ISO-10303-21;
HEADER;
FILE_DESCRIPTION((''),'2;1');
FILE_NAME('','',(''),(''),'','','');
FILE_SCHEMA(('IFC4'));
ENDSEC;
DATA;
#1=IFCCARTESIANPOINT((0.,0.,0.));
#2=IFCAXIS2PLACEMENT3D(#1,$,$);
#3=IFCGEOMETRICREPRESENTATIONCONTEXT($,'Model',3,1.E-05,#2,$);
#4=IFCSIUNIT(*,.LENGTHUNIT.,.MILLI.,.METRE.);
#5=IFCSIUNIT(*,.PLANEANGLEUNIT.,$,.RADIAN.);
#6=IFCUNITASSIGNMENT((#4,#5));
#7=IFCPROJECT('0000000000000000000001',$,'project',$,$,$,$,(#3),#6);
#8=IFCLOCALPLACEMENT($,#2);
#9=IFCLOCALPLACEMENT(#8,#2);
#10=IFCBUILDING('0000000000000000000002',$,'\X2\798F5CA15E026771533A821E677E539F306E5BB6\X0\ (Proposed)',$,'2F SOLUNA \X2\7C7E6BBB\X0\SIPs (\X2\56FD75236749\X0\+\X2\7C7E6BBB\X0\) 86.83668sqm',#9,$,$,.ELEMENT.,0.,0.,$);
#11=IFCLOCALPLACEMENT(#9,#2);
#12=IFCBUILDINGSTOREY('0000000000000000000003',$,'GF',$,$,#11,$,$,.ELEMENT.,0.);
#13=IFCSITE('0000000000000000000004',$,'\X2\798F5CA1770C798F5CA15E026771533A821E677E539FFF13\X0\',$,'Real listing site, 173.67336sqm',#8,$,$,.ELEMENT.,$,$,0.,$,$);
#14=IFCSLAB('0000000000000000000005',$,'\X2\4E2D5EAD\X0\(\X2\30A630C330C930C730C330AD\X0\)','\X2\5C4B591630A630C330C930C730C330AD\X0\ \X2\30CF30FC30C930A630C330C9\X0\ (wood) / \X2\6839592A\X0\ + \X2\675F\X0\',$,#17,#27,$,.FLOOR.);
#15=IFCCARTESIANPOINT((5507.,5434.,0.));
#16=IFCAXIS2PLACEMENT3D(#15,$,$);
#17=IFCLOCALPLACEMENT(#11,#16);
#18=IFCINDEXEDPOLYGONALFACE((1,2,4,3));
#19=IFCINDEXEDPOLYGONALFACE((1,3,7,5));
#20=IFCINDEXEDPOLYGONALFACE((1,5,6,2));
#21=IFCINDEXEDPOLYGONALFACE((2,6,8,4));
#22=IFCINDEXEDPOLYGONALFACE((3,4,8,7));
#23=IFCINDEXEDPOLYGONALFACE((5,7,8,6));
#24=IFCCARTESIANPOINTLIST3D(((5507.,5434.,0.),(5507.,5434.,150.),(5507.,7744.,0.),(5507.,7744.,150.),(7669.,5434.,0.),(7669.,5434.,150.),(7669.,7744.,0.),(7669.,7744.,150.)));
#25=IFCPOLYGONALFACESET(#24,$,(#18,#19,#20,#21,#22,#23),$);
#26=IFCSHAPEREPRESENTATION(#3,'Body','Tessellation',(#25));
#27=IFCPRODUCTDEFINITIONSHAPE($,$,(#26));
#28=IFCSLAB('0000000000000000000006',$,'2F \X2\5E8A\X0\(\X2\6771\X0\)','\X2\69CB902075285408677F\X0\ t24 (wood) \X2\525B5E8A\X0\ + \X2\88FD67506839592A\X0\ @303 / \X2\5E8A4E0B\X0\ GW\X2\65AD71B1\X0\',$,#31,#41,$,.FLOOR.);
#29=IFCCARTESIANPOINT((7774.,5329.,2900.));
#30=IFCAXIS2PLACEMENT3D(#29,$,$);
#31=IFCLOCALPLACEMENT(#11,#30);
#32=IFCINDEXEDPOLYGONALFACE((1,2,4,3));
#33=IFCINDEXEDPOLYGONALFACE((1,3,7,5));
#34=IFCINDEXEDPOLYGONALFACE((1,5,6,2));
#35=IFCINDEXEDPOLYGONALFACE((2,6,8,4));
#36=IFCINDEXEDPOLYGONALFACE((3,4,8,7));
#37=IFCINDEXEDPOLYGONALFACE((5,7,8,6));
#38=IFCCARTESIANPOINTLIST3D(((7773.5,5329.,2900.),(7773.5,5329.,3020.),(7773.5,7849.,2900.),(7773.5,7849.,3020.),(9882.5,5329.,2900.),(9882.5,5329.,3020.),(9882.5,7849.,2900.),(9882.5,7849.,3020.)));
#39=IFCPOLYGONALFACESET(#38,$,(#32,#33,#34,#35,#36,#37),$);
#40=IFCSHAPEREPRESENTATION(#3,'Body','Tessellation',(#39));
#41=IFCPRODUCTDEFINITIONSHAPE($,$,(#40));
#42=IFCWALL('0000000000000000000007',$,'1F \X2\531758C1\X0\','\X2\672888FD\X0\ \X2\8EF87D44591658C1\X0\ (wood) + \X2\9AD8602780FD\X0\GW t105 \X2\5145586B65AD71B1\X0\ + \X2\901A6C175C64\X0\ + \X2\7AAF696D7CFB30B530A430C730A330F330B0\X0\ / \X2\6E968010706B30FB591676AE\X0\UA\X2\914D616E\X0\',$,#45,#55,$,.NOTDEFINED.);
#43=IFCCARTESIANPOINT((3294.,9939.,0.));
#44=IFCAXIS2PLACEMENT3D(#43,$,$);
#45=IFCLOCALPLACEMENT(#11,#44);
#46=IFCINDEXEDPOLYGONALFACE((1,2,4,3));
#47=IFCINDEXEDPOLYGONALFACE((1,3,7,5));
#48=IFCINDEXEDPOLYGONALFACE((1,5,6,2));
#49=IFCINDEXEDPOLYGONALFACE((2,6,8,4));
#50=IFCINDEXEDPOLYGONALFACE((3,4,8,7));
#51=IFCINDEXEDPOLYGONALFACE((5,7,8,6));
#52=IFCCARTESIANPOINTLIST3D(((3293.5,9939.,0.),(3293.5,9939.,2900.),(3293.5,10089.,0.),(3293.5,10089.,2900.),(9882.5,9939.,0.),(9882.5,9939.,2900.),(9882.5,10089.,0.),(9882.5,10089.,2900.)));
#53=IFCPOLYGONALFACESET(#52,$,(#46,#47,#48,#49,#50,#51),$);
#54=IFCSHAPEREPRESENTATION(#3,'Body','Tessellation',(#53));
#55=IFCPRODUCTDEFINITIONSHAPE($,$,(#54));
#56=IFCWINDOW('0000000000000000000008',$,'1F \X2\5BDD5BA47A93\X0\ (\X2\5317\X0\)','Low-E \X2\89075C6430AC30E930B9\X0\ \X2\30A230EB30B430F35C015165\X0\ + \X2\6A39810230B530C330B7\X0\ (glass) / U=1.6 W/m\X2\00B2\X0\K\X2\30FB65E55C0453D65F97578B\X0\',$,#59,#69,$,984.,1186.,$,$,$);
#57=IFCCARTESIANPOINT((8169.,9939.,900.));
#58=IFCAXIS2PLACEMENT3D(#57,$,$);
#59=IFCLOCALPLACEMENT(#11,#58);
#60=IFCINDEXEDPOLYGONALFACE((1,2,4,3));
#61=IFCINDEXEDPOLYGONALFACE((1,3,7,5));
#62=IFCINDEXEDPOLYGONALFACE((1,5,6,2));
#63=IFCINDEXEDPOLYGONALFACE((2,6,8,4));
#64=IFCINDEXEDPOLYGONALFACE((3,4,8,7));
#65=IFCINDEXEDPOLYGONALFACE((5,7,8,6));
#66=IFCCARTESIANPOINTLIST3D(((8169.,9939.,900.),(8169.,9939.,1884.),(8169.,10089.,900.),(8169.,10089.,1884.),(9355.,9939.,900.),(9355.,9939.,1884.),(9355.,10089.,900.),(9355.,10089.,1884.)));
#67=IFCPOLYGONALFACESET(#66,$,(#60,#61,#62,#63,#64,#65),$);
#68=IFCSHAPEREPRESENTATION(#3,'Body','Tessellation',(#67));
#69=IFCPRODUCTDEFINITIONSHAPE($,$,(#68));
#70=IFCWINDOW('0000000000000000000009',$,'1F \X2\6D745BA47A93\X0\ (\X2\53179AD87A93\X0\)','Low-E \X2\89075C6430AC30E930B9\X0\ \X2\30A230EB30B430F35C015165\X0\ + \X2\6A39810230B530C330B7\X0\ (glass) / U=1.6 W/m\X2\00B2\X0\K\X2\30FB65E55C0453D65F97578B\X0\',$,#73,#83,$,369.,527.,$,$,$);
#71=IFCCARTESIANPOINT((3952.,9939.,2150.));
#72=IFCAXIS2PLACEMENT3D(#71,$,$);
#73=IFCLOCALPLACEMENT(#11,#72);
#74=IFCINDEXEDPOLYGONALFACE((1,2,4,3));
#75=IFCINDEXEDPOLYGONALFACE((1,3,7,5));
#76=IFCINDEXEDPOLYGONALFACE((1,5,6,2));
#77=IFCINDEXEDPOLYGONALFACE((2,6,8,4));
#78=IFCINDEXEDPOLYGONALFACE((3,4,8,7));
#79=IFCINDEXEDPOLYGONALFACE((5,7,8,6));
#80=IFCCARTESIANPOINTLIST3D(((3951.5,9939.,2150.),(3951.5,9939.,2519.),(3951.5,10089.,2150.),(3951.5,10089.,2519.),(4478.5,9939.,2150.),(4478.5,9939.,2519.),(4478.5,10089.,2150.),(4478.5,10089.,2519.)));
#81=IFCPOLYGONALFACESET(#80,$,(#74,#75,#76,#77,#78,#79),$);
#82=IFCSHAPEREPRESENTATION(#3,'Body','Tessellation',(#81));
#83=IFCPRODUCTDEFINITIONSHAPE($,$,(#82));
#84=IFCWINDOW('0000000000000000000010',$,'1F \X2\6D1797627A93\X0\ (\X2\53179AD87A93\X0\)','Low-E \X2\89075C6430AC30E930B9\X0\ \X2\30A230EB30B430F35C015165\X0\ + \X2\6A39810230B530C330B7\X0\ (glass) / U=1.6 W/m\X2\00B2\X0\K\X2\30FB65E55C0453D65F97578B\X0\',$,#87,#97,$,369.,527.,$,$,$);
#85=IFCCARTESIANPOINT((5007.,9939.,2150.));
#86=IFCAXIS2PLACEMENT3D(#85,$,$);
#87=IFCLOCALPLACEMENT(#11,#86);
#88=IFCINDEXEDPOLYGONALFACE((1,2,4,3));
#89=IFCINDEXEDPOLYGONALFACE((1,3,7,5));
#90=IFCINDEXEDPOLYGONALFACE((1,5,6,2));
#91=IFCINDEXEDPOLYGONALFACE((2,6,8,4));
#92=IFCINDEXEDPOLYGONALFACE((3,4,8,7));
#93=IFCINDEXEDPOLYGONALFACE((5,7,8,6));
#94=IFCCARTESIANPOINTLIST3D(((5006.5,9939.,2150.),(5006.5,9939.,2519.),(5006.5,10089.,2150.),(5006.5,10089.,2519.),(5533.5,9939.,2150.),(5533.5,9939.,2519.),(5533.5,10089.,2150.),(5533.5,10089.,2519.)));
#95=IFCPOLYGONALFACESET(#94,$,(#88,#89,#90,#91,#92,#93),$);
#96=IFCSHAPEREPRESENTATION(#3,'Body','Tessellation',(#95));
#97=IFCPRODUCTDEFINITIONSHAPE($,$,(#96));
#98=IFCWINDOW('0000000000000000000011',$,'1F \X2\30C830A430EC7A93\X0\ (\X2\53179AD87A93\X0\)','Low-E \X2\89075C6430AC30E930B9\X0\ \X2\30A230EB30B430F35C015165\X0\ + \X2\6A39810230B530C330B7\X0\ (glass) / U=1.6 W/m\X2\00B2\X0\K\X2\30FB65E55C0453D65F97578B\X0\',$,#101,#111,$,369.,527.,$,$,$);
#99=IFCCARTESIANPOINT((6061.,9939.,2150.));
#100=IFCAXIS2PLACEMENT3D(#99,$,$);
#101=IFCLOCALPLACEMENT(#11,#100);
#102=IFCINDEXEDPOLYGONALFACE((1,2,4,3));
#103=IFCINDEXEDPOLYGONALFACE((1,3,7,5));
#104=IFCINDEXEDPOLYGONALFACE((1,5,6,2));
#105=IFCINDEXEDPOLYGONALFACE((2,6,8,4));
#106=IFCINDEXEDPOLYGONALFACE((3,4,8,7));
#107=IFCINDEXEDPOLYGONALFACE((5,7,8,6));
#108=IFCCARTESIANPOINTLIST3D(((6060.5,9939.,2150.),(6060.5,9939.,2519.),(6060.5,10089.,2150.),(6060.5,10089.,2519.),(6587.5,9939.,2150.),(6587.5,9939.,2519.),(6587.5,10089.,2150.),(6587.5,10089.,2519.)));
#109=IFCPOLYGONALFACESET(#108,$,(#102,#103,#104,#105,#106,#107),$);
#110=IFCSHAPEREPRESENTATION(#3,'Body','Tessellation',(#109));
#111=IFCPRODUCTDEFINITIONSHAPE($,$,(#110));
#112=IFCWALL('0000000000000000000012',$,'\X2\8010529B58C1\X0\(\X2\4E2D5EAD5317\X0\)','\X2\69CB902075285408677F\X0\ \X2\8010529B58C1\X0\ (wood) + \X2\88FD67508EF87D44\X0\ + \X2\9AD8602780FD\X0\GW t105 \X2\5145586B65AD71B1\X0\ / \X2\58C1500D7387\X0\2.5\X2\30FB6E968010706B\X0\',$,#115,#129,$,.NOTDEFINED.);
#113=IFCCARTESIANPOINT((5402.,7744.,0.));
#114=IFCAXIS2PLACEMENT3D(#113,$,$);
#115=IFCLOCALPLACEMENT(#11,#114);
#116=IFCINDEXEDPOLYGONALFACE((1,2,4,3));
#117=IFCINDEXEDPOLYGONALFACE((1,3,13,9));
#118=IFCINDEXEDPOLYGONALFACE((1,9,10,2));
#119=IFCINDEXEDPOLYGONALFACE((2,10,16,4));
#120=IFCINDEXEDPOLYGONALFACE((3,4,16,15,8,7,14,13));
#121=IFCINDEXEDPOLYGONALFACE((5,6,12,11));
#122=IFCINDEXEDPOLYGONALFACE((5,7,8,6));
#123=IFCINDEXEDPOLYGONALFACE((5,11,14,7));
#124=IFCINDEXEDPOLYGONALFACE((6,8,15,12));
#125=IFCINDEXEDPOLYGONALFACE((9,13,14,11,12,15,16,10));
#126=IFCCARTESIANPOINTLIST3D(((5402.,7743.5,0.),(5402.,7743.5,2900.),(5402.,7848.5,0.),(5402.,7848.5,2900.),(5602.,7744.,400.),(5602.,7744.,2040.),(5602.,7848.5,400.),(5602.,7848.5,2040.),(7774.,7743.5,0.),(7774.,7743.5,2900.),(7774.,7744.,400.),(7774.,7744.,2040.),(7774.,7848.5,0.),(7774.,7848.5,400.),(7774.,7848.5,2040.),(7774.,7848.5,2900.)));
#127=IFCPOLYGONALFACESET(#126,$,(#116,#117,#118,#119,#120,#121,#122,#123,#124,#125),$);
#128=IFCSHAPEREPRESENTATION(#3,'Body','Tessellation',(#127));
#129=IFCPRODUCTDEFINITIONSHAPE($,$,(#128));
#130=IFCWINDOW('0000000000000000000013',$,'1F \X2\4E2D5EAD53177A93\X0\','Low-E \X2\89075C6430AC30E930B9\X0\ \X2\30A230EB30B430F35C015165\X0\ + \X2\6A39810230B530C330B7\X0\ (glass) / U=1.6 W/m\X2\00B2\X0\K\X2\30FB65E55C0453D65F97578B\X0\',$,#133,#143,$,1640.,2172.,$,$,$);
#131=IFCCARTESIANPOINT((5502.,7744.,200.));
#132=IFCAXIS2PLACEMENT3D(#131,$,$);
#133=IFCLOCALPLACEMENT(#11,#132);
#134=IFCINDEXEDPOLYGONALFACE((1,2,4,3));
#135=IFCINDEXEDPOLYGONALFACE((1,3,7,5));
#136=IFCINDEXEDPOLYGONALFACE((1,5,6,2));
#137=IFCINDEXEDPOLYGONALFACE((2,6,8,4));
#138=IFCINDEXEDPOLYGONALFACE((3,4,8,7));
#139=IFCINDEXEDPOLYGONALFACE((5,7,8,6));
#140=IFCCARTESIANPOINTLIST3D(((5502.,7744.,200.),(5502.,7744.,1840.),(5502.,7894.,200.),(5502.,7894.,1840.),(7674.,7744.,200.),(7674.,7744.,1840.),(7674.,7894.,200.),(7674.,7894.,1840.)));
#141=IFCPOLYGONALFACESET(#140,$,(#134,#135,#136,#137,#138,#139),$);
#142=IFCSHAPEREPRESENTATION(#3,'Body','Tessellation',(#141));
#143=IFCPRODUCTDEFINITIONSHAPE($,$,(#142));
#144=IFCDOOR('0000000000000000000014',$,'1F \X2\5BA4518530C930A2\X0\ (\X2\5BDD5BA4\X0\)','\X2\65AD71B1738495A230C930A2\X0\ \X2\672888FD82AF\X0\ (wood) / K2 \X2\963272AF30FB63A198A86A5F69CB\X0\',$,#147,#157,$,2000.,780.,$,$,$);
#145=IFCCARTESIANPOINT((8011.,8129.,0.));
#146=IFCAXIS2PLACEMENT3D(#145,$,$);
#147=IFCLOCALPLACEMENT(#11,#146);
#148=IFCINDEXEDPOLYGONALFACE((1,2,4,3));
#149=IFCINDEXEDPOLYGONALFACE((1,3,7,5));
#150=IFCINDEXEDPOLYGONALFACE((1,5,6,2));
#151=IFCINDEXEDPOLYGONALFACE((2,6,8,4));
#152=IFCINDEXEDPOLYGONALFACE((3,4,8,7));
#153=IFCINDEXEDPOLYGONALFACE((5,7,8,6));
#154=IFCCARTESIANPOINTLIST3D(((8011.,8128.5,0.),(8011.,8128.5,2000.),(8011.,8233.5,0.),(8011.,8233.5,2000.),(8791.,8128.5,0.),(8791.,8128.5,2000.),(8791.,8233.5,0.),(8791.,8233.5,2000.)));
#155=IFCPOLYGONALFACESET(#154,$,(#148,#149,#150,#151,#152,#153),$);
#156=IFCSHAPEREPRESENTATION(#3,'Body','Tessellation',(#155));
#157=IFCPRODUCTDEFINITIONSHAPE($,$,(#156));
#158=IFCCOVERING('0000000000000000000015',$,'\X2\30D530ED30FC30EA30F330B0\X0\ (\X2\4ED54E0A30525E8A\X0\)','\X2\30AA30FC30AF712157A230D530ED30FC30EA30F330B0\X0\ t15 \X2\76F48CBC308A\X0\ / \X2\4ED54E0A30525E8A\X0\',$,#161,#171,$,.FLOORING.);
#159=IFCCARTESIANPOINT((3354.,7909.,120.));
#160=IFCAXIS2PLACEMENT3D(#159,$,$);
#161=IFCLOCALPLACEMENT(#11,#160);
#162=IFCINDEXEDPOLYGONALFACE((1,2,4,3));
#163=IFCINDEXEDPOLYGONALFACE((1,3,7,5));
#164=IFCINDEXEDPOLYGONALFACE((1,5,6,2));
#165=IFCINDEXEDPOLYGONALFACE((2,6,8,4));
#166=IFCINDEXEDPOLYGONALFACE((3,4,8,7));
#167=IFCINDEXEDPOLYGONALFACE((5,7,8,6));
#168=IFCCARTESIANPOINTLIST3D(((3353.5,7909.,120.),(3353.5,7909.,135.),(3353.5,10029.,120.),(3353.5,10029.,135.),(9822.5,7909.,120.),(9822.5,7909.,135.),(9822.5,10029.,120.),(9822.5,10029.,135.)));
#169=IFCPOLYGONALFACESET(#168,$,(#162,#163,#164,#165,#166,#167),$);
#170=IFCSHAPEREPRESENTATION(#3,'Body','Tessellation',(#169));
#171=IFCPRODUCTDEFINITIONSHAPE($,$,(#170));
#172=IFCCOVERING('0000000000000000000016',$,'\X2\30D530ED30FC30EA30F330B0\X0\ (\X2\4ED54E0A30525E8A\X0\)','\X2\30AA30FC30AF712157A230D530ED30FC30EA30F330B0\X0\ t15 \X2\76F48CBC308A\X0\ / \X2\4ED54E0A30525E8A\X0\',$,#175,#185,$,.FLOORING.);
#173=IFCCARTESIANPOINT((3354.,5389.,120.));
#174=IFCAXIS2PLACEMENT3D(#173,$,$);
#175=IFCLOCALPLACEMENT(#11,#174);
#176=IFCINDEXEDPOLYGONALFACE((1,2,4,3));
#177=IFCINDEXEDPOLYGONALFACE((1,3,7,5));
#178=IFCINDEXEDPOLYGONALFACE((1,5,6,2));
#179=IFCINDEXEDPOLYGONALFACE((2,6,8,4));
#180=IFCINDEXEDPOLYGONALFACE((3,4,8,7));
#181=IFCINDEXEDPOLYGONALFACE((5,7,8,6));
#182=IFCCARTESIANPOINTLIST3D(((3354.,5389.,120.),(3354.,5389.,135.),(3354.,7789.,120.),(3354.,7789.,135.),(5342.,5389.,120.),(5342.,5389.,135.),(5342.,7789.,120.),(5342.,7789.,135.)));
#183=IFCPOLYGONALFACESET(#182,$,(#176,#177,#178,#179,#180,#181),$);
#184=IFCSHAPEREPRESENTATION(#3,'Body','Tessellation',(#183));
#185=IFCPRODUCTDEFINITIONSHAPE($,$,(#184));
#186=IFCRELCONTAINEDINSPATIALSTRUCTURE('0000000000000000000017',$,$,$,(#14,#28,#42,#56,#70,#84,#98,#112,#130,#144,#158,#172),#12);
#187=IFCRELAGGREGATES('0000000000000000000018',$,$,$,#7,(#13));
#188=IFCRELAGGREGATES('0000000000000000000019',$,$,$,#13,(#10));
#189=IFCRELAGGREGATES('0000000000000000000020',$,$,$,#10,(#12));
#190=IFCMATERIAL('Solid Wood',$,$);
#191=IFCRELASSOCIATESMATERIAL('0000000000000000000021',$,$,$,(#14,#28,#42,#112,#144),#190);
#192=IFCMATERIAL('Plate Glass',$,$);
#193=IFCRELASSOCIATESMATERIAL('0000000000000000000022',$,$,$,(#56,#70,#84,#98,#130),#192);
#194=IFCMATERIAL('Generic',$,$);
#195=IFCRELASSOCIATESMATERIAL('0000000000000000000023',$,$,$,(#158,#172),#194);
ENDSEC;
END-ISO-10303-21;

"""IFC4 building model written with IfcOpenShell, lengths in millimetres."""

from ifc_helpers import new_model, si_unit, frame, frame_2d, origin, place, context, project, spatial, rectangle, extrude, material, element, fill, save


model = new_model("IFC4")

# Units and contexts
model_context = context("Model", 3, precision=1e-05, world=origin())
ifc_project = project(units=[si_unit("LENGTHUNIT", "METRE", prefix="MILLI"), si_unit("PLANEANGLEUNIT", "RADIAN")], contexts=[model_context])

# Site, building, storey
site_placement = place(None, origin())
site = spatial("IfcSite", under=ifc_project, at=site_placement, Name="福岡県福岡市東区舞松原３", ObjectType="Real listing site, 173.67336sqm", CompositionType="ELEMENT", RefElevation=0.0)
building_placement = place(site_placement, origin())
building = spatial("IfcBuilding", under=site, at=building_placement, Name="福岡市東区舞松原の家 (Proposed)", ObjectType="2F SOLUNA 籾殻SIPs (国産杉+籾殻) 86.83668sqm", CompositionType="ELEMENT", ElevationOfRefHeight=0.0, ElevationOfTerrain=0.0)
storey_placement = place(building_placement, origin())
storey = spatial("IfcBuildingStorey", under=building, at=storey_placement, Name="GF", CompositionType="ELEMENT", Elevation=0.0)

# Slabs
ifc_material_1 = material(Name="Solid Wood")
slab_1_placement = place(storey_placement, frame((5507.0, 5434.0, 0.0)))
element("IfcSlab", 1, at=slab_1_placement, inside=storey, material=ifc_material_1, Name="中庭(ウッドデッキ)", Description="屋外ウッドデッキ ハードウッド (wood) / 根太 + 束", PredefinedType="FLOOR", context=model_context, shape_type="SweptSolid", body=[
    extrude(rectangle(XDim=2162.0, YDim=2310.0, at=frame_2d((1081.0, 1155.0))), frame((5507.0, 5434.0, 0.0)), (0.0, 0.0, 1.0), 150.0),
])
slab_2_placement = place(storey_placement, frame((7774.0, 5329.0, 2900.0)))
element("IfcSlab", 2, at=slab_2_placement, inside=storey, material=ifc_material_1, Name="2F 床(東)", Description="構造用合板 t24 (wood) 剛床 + 製材根太 @303 / 床下 GW断熱", PredefinedType="FLOOR", context=model_context, shape_type="SweptSolid", body=[
    extrude(rectangle(XDim=2109.0, YDim=2520.0, at=frame_2d((1054.0, 1260.0))), frame((7774.0, 5329.0, 2900.0)), (0.0, 0.0, 1.0), 120.0),
])

# Wall, openings, windows
wall_1_placement = place(storey_placement, frame((3294.0, 9939.0, 0.0)))
wall_1 = element("IfcWall", 3, at=wall_1_placement, inside=storey, material=ifc_material_1, Name="1F 北壁", Description="木製 軸組外壁 (wood) + 高性能GW t105 充填断熱 + 通気層 + 窯業系サイディング / 準耐火・外皮UA配慮", PredefinedType="NOTDEFINED", context=model_context, shape_type="SweptSolid", body=[
    extrude(rectangle(XDim=6589.0, YDim=150.0, at=frame_2d((3294.0, 75.0))), frame((3294.0, 9939.0, 0.0)), (0.0, 0.0, 1.0), 2900.0),
])
opening_1_placement = place(storey_placement, frame((8169.0, 9939.0, 900.0)))
opening_1 = element("IfcOpeningElement", 4, at=opening_1_placement, cuts=wall_1, PredefinedType="NOTDEFINED", context=model_context, shape_type="SweptSolid", body=[
    extrude(rectangle(XDim=1186.0, YDim=150.0, at=frame_2d((593.0, 75.0))), frame((8169.0, 9939.0, 900.0)), (0.0, 0.0, 1.0), 984.0),
])
opening_2_placement = place(storey_placement, frame((3952.0, 9939.0, 2150.0)))
opening_2 = element("IfcOpeningElement", 5, at=opening_2_placement, cuts=wall_1, PredefinedType="NOTDEFINED", context=model_context, shape_type="SweptSolid", body=[
    extrude(rectangle(XDim=527.0, YDim=150.0, at=frame_2d((263.0, 75.0))), frame((3952.0, 9939.0, 2150.0)), (0.0, 0.0, 1.0), 369.0),
])
opening_3_placement = place(storey_placement, frame((5007.0, 9939.0, 2150.0)))
opening_3 = element("IfcOpeningElement", 6, at=opening_3_placement, cuts=wall_1, PredefinedType="NOTDEFINED", context=model_context, shape_type="SweptSolid", body=[
    extrude(rectangle(XDim=527.0, YDim=150.0, at=frame_2d((263.0, 75.0))), frame((5007.0, 9939.0, 2150.0)), (0.0, 0.0, 1.0), 369.0),
])
opening_4_placement = place(storey_placement, frame((6061.0, 9939.0, 2150.0)))
opening_4 = element("IfcOpeningElement", 7, at=opening_4_placement, cuts=wall_1, PredefinedType="NOTDEFINED", context=model_context, shape_type="SweptSolid", body=[
    extrude(rectangle(XDim=527.0, YDim=150.0, at=frame_2d((263.0, 75.0))), frame((6061.0, 9939.0, 2150.0)), (0.0, 0.0, 1.0), 369.0),
])
ifc_material_2 = material(Name="Plate Glass")
window_1_placement = place(storey_placement, frame((8169.0, 9939.0, 900.0)))
window_1 = element("IfcWindow", 8, at=window_1_placement, inside=storey, material=ifc_material_2, Name="1F 寝室窓 (北)", Description="Low-E 複層ガラス アルゴン封入 + 樹脂サッシ (glass) / U=1.6 W/m²K・日射取得型", OverallHeight=984.0, OverallWidth=1186.0, context=model_context, shape_type="SweptSolid", body=[
    extrude(rectangle(XDim=1186.0, YDim=150.0, at=frame_2d((593.0, 75.0))), frame((8169.0, 9939.0, 900.0)), (0.0, 0.0, 1.0), 984.0),
])
fill(opening_1, window_1)
window_2_placement = place(storey_placement, frame((3952.0, 9939.0, 2150.0)))
window_2 = element("IfcWindow", 9, at=window_2_placement, inside=storey, material=ifc_material_2, Name="1F 浴室窓 (北高窓)", Description="Low-E 複層ガラス アルゴン封入 + 樹脂サッシ (glass) / U=1.6 W/m²K・日射取得型", OverallHeight=369.0, OverallWidth=527.0, context=model_context, shape_type="SweptSolid", body=[
    extrude(rectangle(XDim=527.0, YDim=150.0, at=frame_2d((263.0, 75.0))), frame((3952.0, 9939.0, 2150.0)), (0.0, 0.0, 1.0), 369.0),
])
fill(opening_2, window_2)
window_3_placement = place(storey_placement, frame((5007.0, 9939.0, 2150.0)))
window_3 = element("IfcWindow", 10, at=window_3_placement, inside=storey, material=ifc_material_2, Name="1F 洗面窓 (北高窓)", Description="Low-E 複層ガラス アルゴン封入 + 樹脂サッシ (glass) / U=1.6 W/m²K・日射取得型", OverallHeight=369.0, OverallWidth=527.0, context=model_context, shape_type="SweptSolid", body=[
    extrude(rectangle(XDim=527.0, YDim=150.0, at=frame_2d((263.0, 75.0))), frame((5007.0, 9939.0, 2150.0)), (0.0, 0.0, 1.0), 369.0),
])
fill(opening_3, window_3)
window_4_placement = place(storey_placement, frame((6061.0, 9939.0, 2150.0)))
window_4 = element("IfcWindow", 11, at=window_4_placement, inside=storey, material=ifc_material_2, Name="1F トイレ窓 (北高窓)", Description="Low-E 複層ガラス アルゴン封入 + 樹脂サッシ (glass) / U=1.6 W/m²K・日射取得型", OverallHeight=369.0, OverallWidth=527.0, context=model_context, shape_type="SweptSolid", body=[
    extrude(rectangle(XDim=527.0, YDim=150.0, at=frame_2d((263.0, 75.0))), frame((6061.0, 9939.0, 2150.0)), (0.0, 0.0, 1.0), 369.0),
])
fill(opening_4, window_4)

# Wall, opening, window
wall_2_placement = place(storey_placement, frame((5402.0, 7744.0, 0.0)))
wall_2 = element("IfcWall", 12, at=wall_2_placement, inside=storey, material=ifc_material_1, Name="耐力壁(中庭北)", Description="構造用合板 耐力壁 (wood) + 製材軸組 + 高性能GW t105 充填断熱 / 壁倍率2.5・準耐火", PredefinedType="NOTDEFINED", context=model_context, shape_type="SweptSolid", body=[
    extrude(rectangle(XDim=2372.0, YDim=105.0, at=frame_2d((1186.0, 52.0))), frame((5402.0, 7744.0, 0.0)), (0.0, 0.0, 1.0), 2900.0),
])
opening_5_placement = place(storey_placement, frame((5502.0, 7744.0, 200.0)))
opening_5 = element("IfcOpeningElement", 13, at=opening_5_placement, cuts=wall_2, PredefinedType="NOTDEFINED", context=model_context, shape_type="SweptSolid", body=[
    extrude(rectangle(XDim=2172.0, YDim=150.0, at=frame_2d((1086.0, 75.0))), frame((5502.0, 7744.0, 200.0)), (0.0, 0.0, 1.0), 1640.0),
])
window_5_placement = place(storey_placement, frame((5502.0, 7744.0, 200.0)))
window_5 = element("IfcWindow", 14, at=window_5_placement, inside=storey, material=ifc_material_2, Name="1F 中庭北窓", Description="Low-E 複層ガラス アルゴン封入 + 樹脂サッシ (glass) / U=1.6 W/m²K・日射取得型", OverallHeight=1640.0, OverallWidth=2172.0, context=model_context, shape_type="SweptSolid", body=[
    extrude(rectangle(XDim=2172.0, YDim=150.0, at=frame_2d((1086.0, 75.0))), frame((5502.0, 7744.0, 200.0)), (0.0, 0.0, 1.0), 1640.0),
])
fill(opening_5, window_5)

# Door
door_1_placement = place(storey_placement, frame((8011.0, 8129.0, 0.0)))
element("IfcDoor", 15, at=door_1_placement, inside=storey, material=ifc_material_1, Name="1F 室内ドア (寝室)", Description="断熱玄関ドア 木製芯 (wood) / K2 防犯・採風機構", OverallHeight=2000.0, OverallWidth=780.0, context=model_context, shape_type="SweptSolid", body=[
    extrude(rectangle(XDim=780.0, YDim=105.0, at=frame_2d((390.0, 52.0))), frame((8011.0, 8129.0, 0.0)), (0.0, 0.0, 1.0), 2000.0),
])

# Coverings
ifc_material_3 = material(Name="Generic")
covering_1_placement = place(storey_placement, frame((3354.0, 7909.0, 120.0)))
element("IfcCovering", 16, at=covering_1_placement, inside=storey, material=ifc_material_3, Name="フローリング (仕上げ床)", Description="オーク無垢フローリング t15 直貼り / 仕上げ床", PredefinedType="FLOORING", context=model_context, shape_type="SweptSolid", body=[
    extrude(rectangle(XDim=6469.0, YDim=2120.0, at=frame_2d((3234.0, 1060.0))), frame((3354.0, 7909.0, 120.0)), (0.0, 0.0, 1.0), 15.0),
])
covering_2_placement = place(storey_placement, frame((3354.0, 5389.0, 120.0)))
element("IfcCovering", 17, at=covering_2_placement, inside=storey, material=ifc_material_3, Name="フローリング (仕上げ床)", Description="オーク無垢フローリング t15 直貼り / 仕上げ床", PredefinedType="FLOORING", context=model_context, shape_type="SweptSolid", body=[
    extrude(rectangle(XDim=1988.0, YDim=2400.0, at=frame_2d((994.0, 1200.0))), frame((3354.0, 5389.0, 120.0)), (0.0, 0.0, 1.0), 15.0),
])

save(model, "model.ifc")
